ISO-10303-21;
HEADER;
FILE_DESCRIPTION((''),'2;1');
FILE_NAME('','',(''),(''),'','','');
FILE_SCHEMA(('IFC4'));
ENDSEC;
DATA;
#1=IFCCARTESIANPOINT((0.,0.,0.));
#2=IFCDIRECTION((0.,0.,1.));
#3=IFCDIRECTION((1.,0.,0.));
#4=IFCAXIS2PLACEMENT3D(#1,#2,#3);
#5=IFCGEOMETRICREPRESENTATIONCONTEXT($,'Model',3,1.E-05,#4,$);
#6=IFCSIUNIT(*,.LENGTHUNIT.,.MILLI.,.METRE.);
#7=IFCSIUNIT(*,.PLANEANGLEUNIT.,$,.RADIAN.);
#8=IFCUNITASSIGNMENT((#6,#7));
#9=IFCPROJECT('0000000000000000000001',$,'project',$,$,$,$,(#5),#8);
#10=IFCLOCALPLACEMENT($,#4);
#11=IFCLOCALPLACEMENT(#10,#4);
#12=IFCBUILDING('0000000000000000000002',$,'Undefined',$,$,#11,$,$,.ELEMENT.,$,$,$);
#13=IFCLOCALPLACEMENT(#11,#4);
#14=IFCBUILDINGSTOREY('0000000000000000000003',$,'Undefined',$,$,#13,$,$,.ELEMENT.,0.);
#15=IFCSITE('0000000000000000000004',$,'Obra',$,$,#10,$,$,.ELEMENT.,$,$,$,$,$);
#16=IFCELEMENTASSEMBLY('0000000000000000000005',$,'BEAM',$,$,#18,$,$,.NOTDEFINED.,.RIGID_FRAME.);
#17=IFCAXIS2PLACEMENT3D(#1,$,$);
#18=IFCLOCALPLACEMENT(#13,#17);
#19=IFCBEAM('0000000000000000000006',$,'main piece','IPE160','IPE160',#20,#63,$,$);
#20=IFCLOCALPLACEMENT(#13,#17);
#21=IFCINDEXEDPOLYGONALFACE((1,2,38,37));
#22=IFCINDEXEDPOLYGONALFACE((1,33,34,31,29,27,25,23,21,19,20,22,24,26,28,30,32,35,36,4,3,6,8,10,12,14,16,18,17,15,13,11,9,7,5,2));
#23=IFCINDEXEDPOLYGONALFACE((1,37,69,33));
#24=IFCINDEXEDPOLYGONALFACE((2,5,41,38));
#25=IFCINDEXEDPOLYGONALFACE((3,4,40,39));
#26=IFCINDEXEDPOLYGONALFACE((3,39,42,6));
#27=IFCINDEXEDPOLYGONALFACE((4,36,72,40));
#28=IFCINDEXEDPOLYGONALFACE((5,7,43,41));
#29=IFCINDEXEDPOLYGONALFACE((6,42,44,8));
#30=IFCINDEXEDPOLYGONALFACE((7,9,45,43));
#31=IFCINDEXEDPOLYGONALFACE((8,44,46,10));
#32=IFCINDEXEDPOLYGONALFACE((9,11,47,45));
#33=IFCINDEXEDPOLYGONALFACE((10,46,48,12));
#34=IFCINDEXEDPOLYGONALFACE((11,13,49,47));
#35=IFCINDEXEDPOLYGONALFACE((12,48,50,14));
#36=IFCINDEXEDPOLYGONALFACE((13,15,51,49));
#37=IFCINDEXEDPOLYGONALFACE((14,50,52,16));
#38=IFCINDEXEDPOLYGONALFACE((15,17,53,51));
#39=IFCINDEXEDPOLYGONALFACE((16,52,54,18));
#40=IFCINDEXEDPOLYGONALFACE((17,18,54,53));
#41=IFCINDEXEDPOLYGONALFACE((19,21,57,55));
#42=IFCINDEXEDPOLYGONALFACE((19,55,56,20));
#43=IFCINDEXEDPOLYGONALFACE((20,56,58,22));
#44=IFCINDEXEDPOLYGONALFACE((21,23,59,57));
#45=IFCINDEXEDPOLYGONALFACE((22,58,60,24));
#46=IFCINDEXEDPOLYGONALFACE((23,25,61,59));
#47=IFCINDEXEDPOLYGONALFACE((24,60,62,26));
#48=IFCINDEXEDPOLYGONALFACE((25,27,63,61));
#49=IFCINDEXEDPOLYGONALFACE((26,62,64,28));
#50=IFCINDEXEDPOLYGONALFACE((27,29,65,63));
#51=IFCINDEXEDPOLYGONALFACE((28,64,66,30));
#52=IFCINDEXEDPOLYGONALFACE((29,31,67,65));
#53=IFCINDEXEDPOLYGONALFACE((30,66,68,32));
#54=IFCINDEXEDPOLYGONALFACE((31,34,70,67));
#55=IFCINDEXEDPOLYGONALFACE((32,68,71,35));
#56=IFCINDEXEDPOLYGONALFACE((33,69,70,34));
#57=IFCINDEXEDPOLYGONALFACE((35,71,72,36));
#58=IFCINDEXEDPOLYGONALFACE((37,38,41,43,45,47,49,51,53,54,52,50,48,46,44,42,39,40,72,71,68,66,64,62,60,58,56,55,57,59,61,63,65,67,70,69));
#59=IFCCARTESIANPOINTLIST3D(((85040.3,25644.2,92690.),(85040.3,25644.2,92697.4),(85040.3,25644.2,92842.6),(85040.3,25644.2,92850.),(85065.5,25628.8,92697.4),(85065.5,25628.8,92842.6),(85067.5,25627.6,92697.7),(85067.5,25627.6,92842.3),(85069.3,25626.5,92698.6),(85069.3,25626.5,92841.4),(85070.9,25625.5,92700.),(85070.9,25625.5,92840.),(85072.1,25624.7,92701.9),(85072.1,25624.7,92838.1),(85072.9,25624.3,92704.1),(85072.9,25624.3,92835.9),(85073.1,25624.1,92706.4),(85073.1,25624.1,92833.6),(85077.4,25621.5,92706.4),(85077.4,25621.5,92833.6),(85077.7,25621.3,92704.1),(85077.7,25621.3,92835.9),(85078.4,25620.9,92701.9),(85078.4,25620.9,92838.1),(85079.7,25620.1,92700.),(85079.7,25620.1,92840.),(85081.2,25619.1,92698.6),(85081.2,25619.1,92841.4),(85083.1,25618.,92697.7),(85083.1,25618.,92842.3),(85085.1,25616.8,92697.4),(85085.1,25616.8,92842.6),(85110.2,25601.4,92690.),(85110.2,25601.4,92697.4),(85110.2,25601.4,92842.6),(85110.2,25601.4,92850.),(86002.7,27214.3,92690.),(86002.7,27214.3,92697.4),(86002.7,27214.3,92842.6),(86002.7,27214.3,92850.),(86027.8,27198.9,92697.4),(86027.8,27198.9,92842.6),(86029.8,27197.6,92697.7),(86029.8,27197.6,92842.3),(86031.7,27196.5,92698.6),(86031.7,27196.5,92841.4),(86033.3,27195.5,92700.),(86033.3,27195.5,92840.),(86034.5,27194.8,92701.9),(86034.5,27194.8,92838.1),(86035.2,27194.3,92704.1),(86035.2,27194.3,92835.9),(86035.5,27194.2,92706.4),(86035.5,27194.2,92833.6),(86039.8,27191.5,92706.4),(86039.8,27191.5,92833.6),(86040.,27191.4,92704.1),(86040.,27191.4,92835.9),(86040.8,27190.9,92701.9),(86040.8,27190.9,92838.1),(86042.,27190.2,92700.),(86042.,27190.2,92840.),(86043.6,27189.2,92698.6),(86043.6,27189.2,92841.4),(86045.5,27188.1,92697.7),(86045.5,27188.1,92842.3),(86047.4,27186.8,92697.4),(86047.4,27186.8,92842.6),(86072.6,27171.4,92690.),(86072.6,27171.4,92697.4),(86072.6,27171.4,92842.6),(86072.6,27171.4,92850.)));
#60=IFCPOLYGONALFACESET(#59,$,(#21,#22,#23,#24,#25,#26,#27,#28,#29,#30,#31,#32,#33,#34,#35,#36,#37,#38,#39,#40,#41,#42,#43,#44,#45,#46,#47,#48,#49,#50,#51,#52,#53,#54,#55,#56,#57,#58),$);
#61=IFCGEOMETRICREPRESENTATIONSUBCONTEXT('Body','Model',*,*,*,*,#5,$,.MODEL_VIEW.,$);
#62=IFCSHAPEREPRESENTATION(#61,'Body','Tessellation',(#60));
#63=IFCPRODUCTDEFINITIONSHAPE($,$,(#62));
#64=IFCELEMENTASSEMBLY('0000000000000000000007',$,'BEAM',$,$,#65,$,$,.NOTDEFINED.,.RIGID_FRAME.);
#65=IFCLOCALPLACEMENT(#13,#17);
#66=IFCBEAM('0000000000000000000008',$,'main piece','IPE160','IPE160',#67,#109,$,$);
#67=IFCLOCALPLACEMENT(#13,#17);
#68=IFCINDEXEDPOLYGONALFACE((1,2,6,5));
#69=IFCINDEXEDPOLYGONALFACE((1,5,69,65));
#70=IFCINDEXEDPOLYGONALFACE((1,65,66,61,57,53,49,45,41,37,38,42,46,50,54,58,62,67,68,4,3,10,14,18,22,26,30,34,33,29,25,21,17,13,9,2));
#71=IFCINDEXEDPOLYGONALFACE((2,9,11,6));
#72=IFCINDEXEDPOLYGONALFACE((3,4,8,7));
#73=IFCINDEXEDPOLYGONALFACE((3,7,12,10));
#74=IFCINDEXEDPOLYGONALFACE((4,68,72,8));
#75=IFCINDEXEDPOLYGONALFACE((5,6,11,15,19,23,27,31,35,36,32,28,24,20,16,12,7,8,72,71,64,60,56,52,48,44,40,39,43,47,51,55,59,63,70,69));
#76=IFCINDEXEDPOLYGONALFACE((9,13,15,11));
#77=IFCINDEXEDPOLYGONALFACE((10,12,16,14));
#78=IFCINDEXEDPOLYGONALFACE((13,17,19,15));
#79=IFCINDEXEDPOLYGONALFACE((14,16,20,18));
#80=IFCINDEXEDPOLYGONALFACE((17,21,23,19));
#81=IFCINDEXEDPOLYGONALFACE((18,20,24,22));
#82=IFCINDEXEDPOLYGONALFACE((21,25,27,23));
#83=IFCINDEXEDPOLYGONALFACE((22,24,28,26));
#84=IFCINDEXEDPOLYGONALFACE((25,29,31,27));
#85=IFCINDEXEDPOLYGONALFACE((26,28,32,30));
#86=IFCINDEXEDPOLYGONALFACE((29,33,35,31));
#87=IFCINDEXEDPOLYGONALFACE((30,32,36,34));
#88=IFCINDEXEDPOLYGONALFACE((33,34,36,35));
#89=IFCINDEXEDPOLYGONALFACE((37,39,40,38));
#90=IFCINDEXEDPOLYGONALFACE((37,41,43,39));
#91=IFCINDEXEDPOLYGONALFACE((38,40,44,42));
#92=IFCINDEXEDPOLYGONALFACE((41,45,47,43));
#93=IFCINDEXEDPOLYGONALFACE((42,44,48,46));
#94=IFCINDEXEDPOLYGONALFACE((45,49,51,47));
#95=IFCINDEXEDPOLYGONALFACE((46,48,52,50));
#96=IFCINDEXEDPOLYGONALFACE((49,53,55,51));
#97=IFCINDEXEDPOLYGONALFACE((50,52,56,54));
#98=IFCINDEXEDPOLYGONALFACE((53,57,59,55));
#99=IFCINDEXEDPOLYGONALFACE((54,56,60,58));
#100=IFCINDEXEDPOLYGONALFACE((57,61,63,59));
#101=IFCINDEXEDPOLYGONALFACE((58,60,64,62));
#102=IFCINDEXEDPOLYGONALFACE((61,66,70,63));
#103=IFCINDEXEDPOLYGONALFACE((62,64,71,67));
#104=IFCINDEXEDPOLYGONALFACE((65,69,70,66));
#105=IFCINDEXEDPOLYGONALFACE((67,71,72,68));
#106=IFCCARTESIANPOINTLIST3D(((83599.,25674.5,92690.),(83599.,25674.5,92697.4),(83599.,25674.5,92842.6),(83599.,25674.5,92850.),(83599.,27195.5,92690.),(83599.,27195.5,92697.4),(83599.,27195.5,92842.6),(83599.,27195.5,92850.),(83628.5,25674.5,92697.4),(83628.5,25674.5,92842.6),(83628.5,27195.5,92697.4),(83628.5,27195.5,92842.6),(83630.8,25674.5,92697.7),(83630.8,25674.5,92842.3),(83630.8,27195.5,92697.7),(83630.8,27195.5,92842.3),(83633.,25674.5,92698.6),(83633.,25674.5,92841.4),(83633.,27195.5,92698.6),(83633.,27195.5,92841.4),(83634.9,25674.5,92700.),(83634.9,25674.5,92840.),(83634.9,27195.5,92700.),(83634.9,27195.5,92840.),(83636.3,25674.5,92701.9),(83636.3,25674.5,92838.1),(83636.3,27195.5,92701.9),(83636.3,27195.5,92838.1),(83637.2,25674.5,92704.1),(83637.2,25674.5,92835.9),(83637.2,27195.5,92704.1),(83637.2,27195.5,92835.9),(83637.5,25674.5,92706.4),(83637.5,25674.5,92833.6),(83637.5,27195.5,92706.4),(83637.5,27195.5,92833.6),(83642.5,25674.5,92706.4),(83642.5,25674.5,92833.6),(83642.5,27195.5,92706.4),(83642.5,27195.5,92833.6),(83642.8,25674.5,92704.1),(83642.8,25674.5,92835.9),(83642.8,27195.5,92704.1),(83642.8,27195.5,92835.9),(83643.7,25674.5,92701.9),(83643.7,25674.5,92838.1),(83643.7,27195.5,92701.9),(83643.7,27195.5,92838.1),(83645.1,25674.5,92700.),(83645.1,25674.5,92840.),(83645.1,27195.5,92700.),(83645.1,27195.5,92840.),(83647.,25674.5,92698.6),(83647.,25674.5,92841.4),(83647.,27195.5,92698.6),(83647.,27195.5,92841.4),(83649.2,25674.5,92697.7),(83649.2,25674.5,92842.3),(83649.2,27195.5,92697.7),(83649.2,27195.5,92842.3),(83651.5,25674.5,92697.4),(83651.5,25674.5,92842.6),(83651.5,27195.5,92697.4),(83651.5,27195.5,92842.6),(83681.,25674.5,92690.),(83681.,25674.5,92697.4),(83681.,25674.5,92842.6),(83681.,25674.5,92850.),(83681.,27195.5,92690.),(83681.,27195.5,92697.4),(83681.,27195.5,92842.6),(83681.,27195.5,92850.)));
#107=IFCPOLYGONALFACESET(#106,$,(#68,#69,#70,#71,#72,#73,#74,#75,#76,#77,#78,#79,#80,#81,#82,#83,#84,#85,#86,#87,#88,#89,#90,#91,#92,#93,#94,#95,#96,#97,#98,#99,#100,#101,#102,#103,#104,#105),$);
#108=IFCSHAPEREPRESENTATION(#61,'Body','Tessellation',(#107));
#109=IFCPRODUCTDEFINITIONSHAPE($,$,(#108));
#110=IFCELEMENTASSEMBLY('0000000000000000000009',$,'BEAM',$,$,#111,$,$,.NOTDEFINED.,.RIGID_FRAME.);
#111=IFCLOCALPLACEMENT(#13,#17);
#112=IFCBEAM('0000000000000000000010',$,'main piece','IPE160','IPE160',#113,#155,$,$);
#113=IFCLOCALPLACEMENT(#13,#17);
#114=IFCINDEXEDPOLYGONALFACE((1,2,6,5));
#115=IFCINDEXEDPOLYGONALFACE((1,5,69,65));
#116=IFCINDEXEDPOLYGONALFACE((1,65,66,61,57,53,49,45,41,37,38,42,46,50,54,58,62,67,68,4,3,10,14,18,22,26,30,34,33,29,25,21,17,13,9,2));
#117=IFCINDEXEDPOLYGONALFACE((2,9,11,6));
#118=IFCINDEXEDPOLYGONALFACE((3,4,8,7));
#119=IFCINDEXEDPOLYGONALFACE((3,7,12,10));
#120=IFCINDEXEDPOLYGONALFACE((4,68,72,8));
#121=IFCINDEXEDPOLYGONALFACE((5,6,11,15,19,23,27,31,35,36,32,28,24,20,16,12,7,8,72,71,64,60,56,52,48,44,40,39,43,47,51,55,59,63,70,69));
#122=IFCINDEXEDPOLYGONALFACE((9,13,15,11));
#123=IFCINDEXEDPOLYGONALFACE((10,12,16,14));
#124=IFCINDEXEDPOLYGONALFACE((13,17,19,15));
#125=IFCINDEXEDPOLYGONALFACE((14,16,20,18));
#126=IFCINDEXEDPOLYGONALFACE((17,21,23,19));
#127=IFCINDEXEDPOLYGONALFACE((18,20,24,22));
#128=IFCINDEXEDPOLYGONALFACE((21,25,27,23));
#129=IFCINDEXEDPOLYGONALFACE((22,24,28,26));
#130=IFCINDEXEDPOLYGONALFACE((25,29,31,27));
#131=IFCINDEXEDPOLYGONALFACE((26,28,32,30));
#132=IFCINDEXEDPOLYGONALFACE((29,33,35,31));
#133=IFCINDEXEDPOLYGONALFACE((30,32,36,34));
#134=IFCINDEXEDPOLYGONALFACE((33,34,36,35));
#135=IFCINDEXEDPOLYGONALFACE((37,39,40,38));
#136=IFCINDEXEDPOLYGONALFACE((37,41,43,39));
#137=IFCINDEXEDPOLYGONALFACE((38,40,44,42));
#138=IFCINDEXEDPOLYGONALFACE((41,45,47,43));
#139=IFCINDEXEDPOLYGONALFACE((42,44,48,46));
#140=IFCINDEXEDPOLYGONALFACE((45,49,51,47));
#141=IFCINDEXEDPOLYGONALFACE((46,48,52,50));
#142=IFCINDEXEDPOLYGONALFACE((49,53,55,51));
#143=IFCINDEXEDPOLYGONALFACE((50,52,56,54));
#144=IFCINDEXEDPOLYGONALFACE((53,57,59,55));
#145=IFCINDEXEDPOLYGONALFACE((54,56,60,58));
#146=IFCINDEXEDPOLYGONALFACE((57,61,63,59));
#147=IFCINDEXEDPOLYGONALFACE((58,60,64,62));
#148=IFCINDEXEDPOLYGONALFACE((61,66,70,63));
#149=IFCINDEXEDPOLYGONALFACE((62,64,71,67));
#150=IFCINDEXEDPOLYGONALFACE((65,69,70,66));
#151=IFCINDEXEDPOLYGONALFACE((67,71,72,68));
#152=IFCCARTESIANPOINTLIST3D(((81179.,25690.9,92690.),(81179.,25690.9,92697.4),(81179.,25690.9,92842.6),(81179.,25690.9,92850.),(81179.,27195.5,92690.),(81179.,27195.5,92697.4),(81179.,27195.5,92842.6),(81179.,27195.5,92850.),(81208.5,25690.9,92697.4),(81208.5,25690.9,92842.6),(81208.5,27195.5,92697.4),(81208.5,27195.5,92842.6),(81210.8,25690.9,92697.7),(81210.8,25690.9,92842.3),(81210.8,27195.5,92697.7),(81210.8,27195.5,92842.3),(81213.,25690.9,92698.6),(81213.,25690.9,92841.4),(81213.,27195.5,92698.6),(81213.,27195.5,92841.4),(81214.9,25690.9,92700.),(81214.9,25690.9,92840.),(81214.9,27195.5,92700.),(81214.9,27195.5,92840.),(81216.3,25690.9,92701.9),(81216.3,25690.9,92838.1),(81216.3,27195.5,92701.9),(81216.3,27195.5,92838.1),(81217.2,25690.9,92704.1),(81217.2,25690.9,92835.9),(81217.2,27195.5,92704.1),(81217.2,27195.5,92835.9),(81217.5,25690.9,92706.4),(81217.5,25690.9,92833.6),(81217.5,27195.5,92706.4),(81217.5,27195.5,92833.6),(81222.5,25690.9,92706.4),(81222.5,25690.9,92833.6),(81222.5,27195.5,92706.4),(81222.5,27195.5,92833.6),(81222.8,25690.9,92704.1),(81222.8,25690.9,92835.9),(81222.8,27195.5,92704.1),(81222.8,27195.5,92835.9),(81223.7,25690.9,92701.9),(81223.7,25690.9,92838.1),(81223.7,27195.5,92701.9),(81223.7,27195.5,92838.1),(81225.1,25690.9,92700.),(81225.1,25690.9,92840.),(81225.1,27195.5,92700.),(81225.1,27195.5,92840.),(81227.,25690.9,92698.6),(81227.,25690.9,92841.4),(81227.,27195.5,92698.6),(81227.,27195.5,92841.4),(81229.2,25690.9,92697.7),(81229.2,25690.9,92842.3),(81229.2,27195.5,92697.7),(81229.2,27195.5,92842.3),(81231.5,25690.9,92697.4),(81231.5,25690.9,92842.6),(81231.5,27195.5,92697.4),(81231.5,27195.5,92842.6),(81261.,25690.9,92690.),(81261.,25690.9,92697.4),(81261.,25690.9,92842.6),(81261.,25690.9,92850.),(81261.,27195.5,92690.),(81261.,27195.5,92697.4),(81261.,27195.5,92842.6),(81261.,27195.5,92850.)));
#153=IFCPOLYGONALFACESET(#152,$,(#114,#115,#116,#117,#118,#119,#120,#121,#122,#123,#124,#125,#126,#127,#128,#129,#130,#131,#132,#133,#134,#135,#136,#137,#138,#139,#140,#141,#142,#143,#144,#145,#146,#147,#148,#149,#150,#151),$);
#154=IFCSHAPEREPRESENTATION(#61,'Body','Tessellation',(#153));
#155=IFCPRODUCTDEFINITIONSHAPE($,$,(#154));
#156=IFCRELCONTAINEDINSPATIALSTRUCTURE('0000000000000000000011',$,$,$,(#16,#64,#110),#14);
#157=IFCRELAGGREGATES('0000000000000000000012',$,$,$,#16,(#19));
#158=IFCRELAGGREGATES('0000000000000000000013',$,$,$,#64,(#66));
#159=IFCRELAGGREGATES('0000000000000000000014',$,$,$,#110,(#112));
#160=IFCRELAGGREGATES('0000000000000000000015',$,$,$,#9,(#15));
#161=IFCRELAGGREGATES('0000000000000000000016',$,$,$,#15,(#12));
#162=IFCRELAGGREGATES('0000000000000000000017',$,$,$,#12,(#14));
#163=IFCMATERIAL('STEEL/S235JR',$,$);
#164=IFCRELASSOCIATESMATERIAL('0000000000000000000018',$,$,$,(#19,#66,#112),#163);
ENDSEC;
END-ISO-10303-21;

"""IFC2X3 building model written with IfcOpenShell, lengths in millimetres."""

from ifc_helpers import new_model, si_unit, frame, origin_with_axes, origin_2d_with_axis, place, context, subcontext, project, spatial, i_section, extrude, material, element, aggregate, save


model = new_model("IFC2X3")

# Units and contexts
model_context = context("Model", 3, precision=1e-05, world=origin_with_axes())
body_context = subcontext(model_context, "Body", "Model", "MODEL_VIEW")
ifc_project = project(units=[si_unit("LENGTHUNIT", "METRE", prefix="MILLI"), si_unit("PLANEANGLEUNIT", "RADIAN")], contexts=[model_context])

# Site, building, storey
site_placement = place(None, origin_with_axes())
site = spatial("IfcSite", under=ifc_project, at=site_placement, Name="Obra", CompositionType="ELEMENT")
building_placement = place(site_placement, origin_with_axes())
building = spatial("IfcBuilding", under=site, at=building_placement, Name="Undefined", CompositionType="ELEMENT")
storey_placement = place(building_placement, origin_with_axes())
storey = spatial("IfcBuildingStorey", under=building, at=storey_placement, Name="Undefined", CompositionType="ELEMENT", Elevation=0.0)

# Element assemblies, beams
assembly_1_placement = place(storey_placement, origin_with_axes())
assembly_1 = element("IfcElementAssembly", 1, at=assembly_1_placement, inside=storey, Name="BEAM", AssemblyPlace="NOTDEFINED", PredefinedType="RIGID_FRAME")
ifc_material_1 = material(Name="STEEL/S235JR")
beam_1_placement = place(assembly_1_placement, frame((85075.3, 25622.8, 92770.0), z_axis=(0.0, 0.0, 1.0), x_axis=(0.522594, 0.852582, 0.0)))
beam_1 = element("IfcBeam", 2, at=beam_1_placement, material=ifc_material_1, Name="main piece", Description="IPE160", ObjectType="IPE160", context=body_context, shape_type="SweptSolid", body=[
    extrude(i_section(OverallWidth=82.0, OverallDepth=160.0, WebThickness=5.0, FlangeThickness=7.4, FilletRadius=9.0, at=origin_2d_with_axis()), frame((1841.5, 0.0, 0.0), z_axis=(-1.0, 0.0, 0.0), x_axis=(0.0, -1.0, 0.0)), (0.0, 0.0, 1.0), 1841.5),
])
aggregate(assembly_1, [beam_1])
assembly_2_placement = place(storey_placement, origin_with_axes())
assembly_2 = element("IfcElementAssembly", 3, at=assembly_2_placement, inside=storey, Name="BEAM", AssemblyPlace="NOTDEFINED", PredefinedType="RIGID_FRAME")
beam_2_placement = place(assembly_2_placement, frame((83640.0, 25674.5, 92770.0), z_axis=(0.0, 0.0, 1.0), x_axis=(0.000003, 1.0, 0.0)))
beam_2 = element("IfcBeam", 4, at=beam_2_placement, material=ifc_material_1, Name="main piece", Description="IPE160", ObjectType="IPE160", context=body_context, shape_type="SweptSolid", body=[
    extrude(i_section(OverallWidth=82.0, OverallDepth=160.0, WebThickness=5.0, FlangeThickness=7.4, FilletRadius=9.0, at=origin_2d_with_axis()), frame((1521.0, 0.0, 0.0), z_axis=(-1.0, 0.0, 0.0), x_axis=(0.0, -1.0, 0.0)), (0.0, 0.0, 1.0), 1521.0),
])
aggregate(assembly_2, [beam_2])
assembly_3_placement = place(storey_placement, origin_with_axes())
assembly_3 = element("IfcElementAssembly", 5, at=assembly_3_placement, inside=storey, Name="BEAM", AssemblyPlace="NOTDEFINED", PredefinedType="RIGID_FRAME")
beam_3_placement = place(assembly_3_placement, frame((81220.0, 25690.9, 92770.0), z_axis=(0.0, 0.0, 1.0), x_axis=(-0.000002, 1.0, 0.0)))
beam_3 = element("IfcBeam", 6, at=beam_3_placement, material=ifc_material_1, Name="main piece", Description="IPE160", ObjectType="IPE160", context=body_context, shape_type="SweptSolid", body=[
    extrude(i_section(OverallWidth=82.0, OverallDepth=160.0, WebThickness=5.0, FlangeThickness=7.4, FilletRadius=9.0, at=origin_2d_with_axis()), frame((1504.6, 0.0, 0.0), z_axis=(-1.0, 0.0, 0.0), x_axis=(0.0, -1.0, 0.0)), (0.0, 0.0, 1.0), 1504.6),
])
aggregate(assembly_3, [beam_3])

save(model, "model.ifc")
